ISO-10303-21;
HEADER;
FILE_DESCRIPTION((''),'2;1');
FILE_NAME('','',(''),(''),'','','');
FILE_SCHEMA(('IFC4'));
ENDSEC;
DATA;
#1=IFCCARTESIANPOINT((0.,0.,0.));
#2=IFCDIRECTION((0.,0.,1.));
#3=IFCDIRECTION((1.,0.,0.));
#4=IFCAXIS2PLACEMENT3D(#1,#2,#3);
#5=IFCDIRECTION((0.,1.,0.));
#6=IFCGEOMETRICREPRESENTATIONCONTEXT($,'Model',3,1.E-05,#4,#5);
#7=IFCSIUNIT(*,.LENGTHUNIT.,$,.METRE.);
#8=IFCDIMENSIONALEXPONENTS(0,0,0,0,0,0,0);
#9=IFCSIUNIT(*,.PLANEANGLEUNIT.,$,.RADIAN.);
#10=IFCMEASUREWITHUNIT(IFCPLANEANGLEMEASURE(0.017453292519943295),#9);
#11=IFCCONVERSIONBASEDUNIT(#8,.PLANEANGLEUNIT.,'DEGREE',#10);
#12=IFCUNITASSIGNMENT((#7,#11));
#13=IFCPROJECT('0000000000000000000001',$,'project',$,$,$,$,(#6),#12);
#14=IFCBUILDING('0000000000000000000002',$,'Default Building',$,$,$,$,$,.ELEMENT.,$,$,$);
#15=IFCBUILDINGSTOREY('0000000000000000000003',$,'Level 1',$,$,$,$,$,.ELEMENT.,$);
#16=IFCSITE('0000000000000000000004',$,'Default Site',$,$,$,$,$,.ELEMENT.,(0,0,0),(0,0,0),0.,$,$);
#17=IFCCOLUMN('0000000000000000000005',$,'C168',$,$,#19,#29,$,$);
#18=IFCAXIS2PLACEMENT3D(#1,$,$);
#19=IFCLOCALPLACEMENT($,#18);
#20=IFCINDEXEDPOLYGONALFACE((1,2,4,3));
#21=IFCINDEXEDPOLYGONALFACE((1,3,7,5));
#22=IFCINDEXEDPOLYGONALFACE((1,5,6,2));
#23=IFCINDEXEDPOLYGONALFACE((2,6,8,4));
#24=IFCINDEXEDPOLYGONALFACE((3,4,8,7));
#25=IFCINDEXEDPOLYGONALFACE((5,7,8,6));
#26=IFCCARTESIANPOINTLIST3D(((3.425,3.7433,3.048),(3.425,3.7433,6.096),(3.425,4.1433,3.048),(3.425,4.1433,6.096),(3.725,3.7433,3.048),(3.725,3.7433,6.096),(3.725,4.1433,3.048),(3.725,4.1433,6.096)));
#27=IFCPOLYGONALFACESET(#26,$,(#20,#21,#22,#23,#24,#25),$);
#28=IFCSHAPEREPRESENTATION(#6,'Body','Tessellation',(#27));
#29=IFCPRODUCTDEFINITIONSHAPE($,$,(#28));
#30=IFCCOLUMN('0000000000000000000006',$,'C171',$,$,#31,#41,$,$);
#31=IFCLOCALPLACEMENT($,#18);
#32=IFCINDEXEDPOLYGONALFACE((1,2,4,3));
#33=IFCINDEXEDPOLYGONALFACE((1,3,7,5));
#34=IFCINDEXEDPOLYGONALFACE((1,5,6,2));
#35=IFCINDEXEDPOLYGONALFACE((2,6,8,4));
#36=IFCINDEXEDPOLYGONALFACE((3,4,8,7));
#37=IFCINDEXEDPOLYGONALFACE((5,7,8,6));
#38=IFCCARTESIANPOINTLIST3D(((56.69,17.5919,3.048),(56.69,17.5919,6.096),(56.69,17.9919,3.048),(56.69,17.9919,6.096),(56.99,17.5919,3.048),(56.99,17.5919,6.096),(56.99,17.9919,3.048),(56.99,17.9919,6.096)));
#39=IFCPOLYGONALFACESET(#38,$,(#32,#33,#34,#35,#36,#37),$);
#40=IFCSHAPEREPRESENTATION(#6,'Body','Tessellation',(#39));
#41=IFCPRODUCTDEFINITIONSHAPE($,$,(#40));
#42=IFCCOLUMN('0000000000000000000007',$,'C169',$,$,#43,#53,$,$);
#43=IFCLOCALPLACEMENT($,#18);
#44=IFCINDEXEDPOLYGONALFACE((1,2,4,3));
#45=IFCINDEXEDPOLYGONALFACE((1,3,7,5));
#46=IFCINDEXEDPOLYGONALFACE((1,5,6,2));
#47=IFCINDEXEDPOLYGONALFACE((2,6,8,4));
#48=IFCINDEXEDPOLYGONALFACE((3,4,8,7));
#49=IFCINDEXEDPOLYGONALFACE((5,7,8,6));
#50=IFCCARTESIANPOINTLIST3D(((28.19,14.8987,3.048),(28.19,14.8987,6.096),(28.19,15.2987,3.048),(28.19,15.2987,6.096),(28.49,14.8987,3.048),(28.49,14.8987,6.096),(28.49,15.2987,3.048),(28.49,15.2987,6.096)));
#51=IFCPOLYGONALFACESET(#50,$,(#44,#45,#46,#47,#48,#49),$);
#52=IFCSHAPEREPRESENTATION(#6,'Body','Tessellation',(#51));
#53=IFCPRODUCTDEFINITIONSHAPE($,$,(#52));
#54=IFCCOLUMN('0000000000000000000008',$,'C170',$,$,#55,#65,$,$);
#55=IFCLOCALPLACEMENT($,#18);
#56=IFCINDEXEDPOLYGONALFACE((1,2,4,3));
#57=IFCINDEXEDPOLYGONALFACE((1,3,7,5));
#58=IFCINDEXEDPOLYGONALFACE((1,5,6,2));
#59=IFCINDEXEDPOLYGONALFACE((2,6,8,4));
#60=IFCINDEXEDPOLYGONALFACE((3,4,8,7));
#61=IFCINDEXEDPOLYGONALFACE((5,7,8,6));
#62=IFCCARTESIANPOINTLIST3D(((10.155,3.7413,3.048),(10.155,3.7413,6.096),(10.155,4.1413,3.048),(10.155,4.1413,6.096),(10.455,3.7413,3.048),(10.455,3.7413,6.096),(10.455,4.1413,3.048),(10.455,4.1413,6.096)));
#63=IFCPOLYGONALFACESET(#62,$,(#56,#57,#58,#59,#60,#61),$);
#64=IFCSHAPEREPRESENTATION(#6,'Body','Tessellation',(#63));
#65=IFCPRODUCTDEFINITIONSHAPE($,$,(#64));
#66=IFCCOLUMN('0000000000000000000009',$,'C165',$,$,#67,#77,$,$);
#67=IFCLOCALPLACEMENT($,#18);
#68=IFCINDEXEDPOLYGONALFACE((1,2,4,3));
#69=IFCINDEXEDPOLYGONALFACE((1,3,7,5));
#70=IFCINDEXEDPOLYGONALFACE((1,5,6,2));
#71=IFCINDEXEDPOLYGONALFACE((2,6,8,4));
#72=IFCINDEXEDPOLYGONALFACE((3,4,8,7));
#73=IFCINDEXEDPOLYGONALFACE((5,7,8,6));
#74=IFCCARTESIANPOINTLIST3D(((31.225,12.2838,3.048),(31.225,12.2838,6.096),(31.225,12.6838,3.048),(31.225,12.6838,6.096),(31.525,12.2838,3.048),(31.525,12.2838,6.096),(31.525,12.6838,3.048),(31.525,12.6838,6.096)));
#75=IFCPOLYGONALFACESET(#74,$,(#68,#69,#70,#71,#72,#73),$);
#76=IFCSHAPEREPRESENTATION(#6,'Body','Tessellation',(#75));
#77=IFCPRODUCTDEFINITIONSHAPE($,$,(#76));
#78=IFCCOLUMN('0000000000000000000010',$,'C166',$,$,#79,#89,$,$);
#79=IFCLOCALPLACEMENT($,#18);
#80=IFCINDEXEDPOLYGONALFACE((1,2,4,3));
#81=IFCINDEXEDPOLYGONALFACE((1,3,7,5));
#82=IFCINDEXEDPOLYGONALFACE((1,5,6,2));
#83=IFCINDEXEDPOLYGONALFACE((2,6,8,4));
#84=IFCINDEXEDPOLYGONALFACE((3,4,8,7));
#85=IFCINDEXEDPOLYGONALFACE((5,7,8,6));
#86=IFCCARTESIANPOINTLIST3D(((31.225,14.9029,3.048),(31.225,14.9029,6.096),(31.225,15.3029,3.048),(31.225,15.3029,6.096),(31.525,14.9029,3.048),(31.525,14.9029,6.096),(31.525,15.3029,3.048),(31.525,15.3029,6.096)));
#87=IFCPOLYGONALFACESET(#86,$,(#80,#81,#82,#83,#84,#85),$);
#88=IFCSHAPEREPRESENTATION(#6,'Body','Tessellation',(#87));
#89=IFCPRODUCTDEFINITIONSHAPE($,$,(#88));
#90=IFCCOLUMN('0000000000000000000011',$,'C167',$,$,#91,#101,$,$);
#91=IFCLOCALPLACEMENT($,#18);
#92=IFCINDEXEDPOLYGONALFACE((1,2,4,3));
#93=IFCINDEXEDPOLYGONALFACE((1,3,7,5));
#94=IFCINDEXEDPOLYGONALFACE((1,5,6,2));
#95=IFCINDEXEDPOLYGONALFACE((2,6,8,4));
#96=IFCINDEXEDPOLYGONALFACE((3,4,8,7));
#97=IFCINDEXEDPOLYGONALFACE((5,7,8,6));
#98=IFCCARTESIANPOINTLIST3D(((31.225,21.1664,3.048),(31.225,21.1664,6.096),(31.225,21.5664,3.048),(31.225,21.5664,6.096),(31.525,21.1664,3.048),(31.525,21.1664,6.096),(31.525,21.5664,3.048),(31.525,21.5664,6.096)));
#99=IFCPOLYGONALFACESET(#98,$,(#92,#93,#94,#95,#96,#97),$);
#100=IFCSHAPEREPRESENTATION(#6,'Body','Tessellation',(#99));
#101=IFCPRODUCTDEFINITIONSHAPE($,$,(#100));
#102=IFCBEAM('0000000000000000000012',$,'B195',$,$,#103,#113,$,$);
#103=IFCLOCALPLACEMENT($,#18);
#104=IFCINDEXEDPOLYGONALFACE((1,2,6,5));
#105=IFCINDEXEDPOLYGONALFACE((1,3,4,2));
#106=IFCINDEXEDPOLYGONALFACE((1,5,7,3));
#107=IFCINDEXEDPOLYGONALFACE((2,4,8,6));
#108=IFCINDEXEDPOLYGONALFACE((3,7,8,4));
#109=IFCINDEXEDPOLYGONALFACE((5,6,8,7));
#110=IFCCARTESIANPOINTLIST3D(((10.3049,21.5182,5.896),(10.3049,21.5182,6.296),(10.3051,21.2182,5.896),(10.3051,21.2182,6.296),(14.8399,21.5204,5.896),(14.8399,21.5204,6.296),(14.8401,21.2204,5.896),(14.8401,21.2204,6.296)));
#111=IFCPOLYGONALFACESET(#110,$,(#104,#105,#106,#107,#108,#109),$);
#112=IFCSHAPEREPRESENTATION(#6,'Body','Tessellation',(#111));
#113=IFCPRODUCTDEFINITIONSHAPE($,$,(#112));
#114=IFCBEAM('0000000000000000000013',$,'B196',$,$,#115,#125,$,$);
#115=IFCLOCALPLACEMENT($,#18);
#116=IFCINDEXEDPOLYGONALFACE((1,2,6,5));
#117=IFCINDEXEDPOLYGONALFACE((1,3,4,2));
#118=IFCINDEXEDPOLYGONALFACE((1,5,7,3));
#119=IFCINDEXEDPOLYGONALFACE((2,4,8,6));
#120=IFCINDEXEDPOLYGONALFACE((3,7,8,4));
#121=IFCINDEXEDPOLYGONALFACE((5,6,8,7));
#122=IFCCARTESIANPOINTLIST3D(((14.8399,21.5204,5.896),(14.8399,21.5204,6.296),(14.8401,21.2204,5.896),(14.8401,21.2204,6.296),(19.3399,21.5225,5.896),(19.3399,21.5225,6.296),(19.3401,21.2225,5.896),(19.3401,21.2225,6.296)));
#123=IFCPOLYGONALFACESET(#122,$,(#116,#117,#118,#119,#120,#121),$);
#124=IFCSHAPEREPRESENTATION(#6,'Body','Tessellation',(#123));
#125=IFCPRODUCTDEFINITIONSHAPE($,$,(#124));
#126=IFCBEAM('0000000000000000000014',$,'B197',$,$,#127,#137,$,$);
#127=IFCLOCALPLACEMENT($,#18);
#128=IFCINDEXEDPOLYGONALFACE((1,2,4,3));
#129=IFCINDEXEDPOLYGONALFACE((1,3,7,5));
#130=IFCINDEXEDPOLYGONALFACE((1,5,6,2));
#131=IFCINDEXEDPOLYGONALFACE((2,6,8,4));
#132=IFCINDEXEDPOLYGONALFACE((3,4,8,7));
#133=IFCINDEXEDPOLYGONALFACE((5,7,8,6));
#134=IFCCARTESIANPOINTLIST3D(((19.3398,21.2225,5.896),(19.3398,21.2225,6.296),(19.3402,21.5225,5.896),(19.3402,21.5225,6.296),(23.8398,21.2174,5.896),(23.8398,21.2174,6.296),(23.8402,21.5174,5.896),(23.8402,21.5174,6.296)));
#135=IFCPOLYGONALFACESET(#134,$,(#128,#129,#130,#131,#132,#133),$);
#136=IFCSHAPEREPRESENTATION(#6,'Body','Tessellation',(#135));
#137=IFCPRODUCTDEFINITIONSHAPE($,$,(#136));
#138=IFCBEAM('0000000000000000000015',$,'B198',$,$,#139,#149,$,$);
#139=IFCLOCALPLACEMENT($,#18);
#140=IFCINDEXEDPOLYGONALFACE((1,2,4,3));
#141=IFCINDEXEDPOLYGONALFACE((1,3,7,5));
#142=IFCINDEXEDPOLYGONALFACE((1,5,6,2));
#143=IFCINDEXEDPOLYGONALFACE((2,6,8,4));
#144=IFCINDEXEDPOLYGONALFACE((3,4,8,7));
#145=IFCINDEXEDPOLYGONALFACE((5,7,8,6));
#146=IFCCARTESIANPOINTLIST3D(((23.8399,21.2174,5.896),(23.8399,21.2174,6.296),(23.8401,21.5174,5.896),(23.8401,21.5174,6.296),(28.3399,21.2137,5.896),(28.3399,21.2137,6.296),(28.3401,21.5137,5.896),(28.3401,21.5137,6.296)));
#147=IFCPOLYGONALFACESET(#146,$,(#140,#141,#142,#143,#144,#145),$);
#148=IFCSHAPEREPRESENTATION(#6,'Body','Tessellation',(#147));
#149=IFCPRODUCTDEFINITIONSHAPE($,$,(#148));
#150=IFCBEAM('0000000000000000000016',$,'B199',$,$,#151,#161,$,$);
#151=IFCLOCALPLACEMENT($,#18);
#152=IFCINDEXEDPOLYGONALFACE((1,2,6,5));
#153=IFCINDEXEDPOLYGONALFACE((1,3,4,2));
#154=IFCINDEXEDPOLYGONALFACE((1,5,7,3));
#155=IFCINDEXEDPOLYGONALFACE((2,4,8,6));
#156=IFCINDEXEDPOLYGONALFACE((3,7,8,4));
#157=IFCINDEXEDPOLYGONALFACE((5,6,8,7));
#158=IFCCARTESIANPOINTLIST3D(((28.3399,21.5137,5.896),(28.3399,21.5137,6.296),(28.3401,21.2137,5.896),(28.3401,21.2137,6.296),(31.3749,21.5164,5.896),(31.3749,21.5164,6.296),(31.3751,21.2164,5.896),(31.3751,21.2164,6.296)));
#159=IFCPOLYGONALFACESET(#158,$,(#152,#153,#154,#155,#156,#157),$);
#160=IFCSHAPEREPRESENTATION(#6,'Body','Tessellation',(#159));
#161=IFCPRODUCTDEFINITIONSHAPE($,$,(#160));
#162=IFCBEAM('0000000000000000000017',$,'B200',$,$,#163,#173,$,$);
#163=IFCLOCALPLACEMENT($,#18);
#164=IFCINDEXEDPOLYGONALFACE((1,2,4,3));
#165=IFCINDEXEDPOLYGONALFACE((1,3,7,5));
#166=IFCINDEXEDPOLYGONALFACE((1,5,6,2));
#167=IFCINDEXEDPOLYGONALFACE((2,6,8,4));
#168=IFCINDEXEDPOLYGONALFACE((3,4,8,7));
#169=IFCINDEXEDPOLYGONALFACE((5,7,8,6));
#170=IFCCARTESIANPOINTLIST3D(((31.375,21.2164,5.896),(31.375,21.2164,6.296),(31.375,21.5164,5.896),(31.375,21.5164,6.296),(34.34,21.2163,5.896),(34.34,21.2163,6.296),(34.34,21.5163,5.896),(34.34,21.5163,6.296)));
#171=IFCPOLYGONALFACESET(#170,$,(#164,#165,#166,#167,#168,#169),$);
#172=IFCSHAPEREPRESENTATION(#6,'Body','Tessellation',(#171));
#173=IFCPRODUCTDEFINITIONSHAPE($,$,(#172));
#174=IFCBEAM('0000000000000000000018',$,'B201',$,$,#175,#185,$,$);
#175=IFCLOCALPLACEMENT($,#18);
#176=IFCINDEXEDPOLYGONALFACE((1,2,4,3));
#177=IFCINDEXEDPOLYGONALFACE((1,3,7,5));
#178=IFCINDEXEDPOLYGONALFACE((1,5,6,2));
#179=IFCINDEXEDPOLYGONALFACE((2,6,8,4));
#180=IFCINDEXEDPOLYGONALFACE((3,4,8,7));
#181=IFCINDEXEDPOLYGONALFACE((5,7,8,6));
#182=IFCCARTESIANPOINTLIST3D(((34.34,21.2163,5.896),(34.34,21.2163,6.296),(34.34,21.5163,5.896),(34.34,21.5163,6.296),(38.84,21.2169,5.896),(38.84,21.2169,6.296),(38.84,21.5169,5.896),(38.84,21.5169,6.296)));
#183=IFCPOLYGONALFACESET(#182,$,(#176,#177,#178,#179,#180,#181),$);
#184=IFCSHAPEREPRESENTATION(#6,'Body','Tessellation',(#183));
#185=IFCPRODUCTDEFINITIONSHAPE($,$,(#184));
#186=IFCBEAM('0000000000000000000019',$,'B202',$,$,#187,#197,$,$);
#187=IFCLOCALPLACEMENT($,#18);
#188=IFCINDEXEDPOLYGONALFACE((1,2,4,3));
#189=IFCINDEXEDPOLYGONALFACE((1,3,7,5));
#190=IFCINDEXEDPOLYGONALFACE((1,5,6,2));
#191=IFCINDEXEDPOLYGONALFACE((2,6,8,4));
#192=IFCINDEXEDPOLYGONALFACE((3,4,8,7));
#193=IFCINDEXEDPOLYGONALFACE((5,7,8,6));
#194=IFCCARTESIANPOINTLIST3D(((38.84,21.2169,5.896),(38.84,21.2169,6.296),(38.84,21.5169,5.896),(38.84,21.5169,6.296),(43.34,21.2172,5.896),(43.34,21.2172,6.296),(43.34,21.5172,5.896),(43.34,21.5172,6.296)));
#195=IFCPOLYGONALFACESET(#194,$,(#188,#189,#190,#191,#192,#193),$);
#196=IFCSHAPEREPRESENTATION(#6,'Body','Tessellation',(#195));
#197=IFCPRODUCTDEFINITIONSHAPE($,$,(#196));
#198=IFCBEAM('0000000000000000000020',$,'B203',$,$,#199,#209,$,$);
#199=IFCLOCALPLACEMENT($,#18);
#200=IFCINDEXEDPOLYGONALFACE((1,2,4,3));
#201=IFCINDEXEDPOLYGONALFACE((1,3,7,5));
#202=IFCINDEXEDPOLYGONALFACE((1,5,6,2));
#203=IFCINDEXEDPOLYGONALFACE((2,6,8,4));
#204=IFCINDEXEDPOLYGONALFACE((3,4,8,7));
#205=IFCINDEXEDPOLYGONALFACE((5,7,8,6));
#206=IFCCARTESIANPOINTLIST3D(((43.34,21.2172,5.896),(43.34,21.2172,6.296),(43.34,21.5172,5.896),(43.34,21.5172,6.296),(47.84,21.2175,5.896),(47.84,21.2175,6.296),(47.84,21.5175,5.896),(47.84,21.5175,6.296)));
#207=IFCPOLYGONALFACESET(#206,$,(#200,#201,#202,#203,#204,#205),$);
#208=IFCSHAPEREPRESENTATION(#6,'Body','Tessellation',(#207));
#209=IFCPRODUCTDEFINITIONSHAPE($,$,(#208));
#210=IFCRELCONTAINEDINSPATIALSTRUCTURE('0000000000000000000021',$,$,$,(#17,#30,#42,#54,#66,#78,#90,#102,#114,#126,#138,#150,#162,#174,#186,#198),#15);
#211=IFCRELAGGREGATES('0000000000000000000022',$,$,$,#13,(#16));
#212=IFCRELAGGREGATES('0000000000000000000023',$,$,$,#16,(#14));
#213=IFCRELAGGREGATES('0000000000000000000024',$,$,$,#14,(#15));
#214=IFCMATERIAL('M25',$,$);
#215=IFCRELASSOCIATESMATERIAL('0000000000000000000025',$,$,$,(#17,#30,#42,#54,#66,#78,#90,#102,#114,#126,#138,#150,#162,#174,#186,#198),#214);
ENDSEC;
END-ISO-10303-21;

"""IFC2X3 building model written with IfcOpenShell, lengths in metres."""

from ifc_helpers import new_model, entity, si_unit, converted_unit, direction, frame, frame_2d, origin_with_axes, place, context, project, spatial, rectangle, extrude, material, element, save


model = new_model("IFC2X3")

# Units and contexts
model_context = context("Model", 3, precision=1e-05, world=origin_with_axes(), true_north=direction((0.0, 1.0, 0.0)))
ifc_project = project(units=[si_unit("LENGTHUNIT", "METRE"), converted_unit("PLANEANGLEUNIT", "DEGREE", entity("IfcPlaneAngleMeasure", 0.017453292519943295), si_unit("PLANEANGLEUNIT", "RADIAN"), dimensions=[0, 0, 0, 0, 0, 0, 0])], contexts=[model_context])

# Site, building, storey
site = spatial("IfcSite", under=ifc_project, Name="Default Site", CompositionType="ELEMENT", RefLatitude=(0, 0, 0), RefLongitude=(0, 0, 0), RefElevation=0.0)
building = spatial("IfcBuilding", under=site, Name="Default Building", CompositionType="ELEMENT")
storey = spatial("IfcBuildingStorey", under=building, Name="Level 1", CompositionType="ELEMENT")

# Columns
ifc_material = material(Name="M25")
placement = place(None, origin_with_axes())
element("IfcColumn", 1, at=placement, inside=storey, material=ifc_material, Name="C168", context=model_context, shape_type="SweptSolid", body=[
    extrude(rectangle(XDim=0.3, YDim=0.4, at=frame_2d((0.0, 0.0), x_axis=(1.0, 0.0, 0.0))), frame((3.575, 3.9433, 3.048), z_axis=(0.0, 0.0, 1.0), x_axis=(1.0, 0.0, 0.0)), (0.0, 0.0, 1.0), 3.048),
])
element("IfcColumn", 2, at=placement, inside=storey, material=ifc_material, Name="C171", context=model_context, shape_type="SweptSolid", body=[
    extrude(rectangle(XDim=0.3, YDim=0.4, at=frame_2d((0.0, 0.0), x_axis=(1.0, 0.0, 0.0))), frame((56.84, 17.7919, 3.048), z_axis=(0.0, 0.0, 1.0), x_axis=(1.0, 0.0, 0.0)), (0.0, 0.0, 1.0), 3.048),
])
element("IfcColumn", 3, at=placement, inside=storey, material=ifc_material, Name="C169", context=model_context, shape_type="SweptSolid", body=[
    extrude(rectangle(XDim=0.3, YDim=0.4, at=frame_2d((0.0, 0.0), x_axis=(1.0, 0.0, 0.0))), frame((28.34, 15.0987, 3.048), z_axis=(0.0, 0.0, 1.0), x_axis=(1.0, 0.0, 0.0)), (0.0, 0.0, 1.0), 3.048),
])
element("IfcColumn", 4, at=placement, inside=storey, material=ifc_material, Name="C170", context=model_context, shape_type="SweptSolid", body=[
    extrude(rectangle(XDim=0.3, YDim=0.4, at=frame_2d((0.0, 0.0), x_axis=(1.0, 0.0, 0.0))), frame((10.305, 3.9413, 3.048), z_axis=(0.0, 0.0, 1.0), x_axis=(1.0, 0.0, 0.0)), (0.0, 0.0, 1.0), 3.048),
])
element("IfcColumn", 5, at=placement, inside=storey, material=ifc_material, Name="C165", context=model_context, shape_type="SweptSolid", body=[
    extrude(rectangle(XDim=0.3, YDim=0.4, at=frame_2d((0.0, 0.0), x_axis=(1.0, 0.0, 0.0))), frame((31.375, 12.4838, 3.048), z_axis=(0.0, 0.0, 1.0), x_axis=(1.0, 0.0, 0.0)), (0.0, 0.0, 1.0), 3.048),
])
element("IfcColumn", 6, at=placement, inside=storey, material=ifc_material, Name="C166", context=model_context, shape_type="SweptSolid", body=[
    extrude(rectangle(XDim=0.3, YDim=0.4, at=frame_2d((0.0, 0.0), x_axis=(1.0, 0.0, 0.0))), frame((31.375, 15.1029, 3.048), z_axis=(0.0, 0.0, 1.0), x_axis=(1.0, 0.0, 0.0)), (0.0, 0.0, 1.0), 3.048),
])
element("IfcColumn", 7, at=placement, inside=storey, material=ifc_material, Name="C167", context=model_context, shape_type="SweptSolid", body=[
    extrude(rectangle(XDim=0.3, YDim=0.4, at=frame_2d((0.0, 0.0), x_axis=(1.0, 0.0, 0.0))), frame((31.375, 21.3664, 3.048), z_axis=(0.0, 0.0, 1.0), x_axis=(1.0, 0.0, 0.0)), (0.0, 0.0, 1.0), 3.048),
])

# Beams
element("IfcBeam", 8, at=placement, inside=storey, material=ifc_material, Name="B195", context=model_context, shape_type="SweptSolid", body=[
    extrude(rectangle(XDim=0.3, YDim=0.4, at=frame_2d((0.0, 0.0), x_axis=(0.0, 1.0, 0.0))), frame((10.305, 21.3682, 6.096), z_axis=(1.0, 0.000476, 0.0), x_axis=(0.0, 0.0, -1.0)), (0.0, 0.0, 1.0), 4.535),
])
element("IfcBeam", 9, at=placement, inside=storey, material=ifc_material, Name="B196", context=model_context, shape_type="SweptSolid", body=[
    extrude(rectangle(XDim=0.3, YDim=0.4, at=frame_2d((0.0, 0.0), x_axis=(0.0, 1.0, 0.0))), frame((14.84, 21.3704, 6.096), z_axis=(1.0, 0.000471, 0.0), x_axis=(0.0, 0.0, -1.0)), (0.0, 0.0, 1.0), 4.5),
])
element("IfcBeam", 10, at=placement, inside=storey, material=ifc_material, Name="B197", context=model_context, shape_type="SweptSolid", body=[
    extrude(rectangle(XDim=0.3, YDim=0.4, at=frame_2d((0.0, 0.0), x_axis=(0.0, 1.0, 0.0))), frame((19.34, 21.3725, 6.096), z_axis=(0.999999, -0.001141, 0.0), x_axis=(0.0, 0.0, -1.0)), (0.0, 0.0, 1.0), 4.5),
])
element("IfcBeam", 11, at=placement, inside=storey, material=ifc_material, Name="B198", context=model_context, shape_type="SweptSolid", body=[
    extrude(rectangle(XDim=0.3, YDim=0.4, at=frame_2d((0.0, 0.0), x_axis=(0.0, 1.0, 0.0))), frame((23.84, 21.3674, 6.096), z_axis=(1.0, -0.000812, 0.0), x_axis=(0.0, 0.0, -1.0)), (0.0, 0.0, 1.0), 4.5),
])
element("IfcBeam", 12, at=placement, inside=storey, material=ifc_material, Name="B199", context=model_context, shape_type="SweptSolid", body=[
    extrude(rectangle(XDim=0.3, YDim=0.4, at=frame_2d((0.0, 0.0), x_axis=(0.0, 1.0, 0.0))), frame((28.34, 21.3637, 6.096), z_axis=(1.0, 0.000883, 0.0), x_axis=(0.0, 0.0, -1.0)), (0.0, 0.0, 1.0), 3.035),
])
element("IfcBeam", 13, at=placement, inside=storey, material=ifc_material, Name="B200", context=model_context, shape_type="SweptSolid", body=[
    extrude(rectangle(XDim=0.3, YDim=0.4, at=frame_2d((0.0, 0.0), x_axis=(0.0, 1.0, 0.0))), frame((31.375, 21.3664, 6.096), z_axis=(1.0, -0.000016, 0.0), x_axis=(0.0, 0.0, -1.0)), (0.0, 0.0, 1.0), 2.965),
])
element("IfcBeam", 14, at=placement, inside=storey, material=ifc_material, Name="B201", context=model_context, shape_type="SweptSolid", body=[
    extrude(rectangle(XDim=0.3, YDim=0.4, at=frame_2d((0.0, 0.0), x_axis=(0.0, 1.0, 0.0))), frame((34.34, 21.3663, 6.096), z_axis=(1.0, 0.000136, 0.0), x_axis=(0.0, 0.0, -1.0)), (0.0, 0.0, 1.0), 4.5),
])
element("IfcBeam", 15, at=placement, inside=storey, material=ifc_material, Name="B202", context=model_context, shape_type="SweptSolid", body=[
    extrude(rectangle(XDim=0.3, YDim=0.4, at=frame_2d((0.0, 0.0), x_axis=(0.0, 1.0, 0.0))), frame((38.84, 21.3669, 6.096), z_axis=(1.0, 0.00005, 0.0), x_axis=(0.0, 0.0, -1.0)), (0.0, 0.0, 1.0), 4.5),
])
element("IfcBeam", 16, at=placement, inside=storey, material=ifc_material, Name="B203", context=model_context, shape_type="SweptSolid", body=[
    extrude(rectangle(XDim=0.3, YDim=0.4, at=frame_2d((0.0, 0.0), x_axis=(0.0, 1.0, 0.0))), frame((43.34, 21.3672, 6.096), z_axis=(1.0, 0.000075, 0.0), x_axis=(0.0, 0.0, -1.0)), (0.0, 0.0, 1.0), 4.5),
])

save(model, "model.ifc")
